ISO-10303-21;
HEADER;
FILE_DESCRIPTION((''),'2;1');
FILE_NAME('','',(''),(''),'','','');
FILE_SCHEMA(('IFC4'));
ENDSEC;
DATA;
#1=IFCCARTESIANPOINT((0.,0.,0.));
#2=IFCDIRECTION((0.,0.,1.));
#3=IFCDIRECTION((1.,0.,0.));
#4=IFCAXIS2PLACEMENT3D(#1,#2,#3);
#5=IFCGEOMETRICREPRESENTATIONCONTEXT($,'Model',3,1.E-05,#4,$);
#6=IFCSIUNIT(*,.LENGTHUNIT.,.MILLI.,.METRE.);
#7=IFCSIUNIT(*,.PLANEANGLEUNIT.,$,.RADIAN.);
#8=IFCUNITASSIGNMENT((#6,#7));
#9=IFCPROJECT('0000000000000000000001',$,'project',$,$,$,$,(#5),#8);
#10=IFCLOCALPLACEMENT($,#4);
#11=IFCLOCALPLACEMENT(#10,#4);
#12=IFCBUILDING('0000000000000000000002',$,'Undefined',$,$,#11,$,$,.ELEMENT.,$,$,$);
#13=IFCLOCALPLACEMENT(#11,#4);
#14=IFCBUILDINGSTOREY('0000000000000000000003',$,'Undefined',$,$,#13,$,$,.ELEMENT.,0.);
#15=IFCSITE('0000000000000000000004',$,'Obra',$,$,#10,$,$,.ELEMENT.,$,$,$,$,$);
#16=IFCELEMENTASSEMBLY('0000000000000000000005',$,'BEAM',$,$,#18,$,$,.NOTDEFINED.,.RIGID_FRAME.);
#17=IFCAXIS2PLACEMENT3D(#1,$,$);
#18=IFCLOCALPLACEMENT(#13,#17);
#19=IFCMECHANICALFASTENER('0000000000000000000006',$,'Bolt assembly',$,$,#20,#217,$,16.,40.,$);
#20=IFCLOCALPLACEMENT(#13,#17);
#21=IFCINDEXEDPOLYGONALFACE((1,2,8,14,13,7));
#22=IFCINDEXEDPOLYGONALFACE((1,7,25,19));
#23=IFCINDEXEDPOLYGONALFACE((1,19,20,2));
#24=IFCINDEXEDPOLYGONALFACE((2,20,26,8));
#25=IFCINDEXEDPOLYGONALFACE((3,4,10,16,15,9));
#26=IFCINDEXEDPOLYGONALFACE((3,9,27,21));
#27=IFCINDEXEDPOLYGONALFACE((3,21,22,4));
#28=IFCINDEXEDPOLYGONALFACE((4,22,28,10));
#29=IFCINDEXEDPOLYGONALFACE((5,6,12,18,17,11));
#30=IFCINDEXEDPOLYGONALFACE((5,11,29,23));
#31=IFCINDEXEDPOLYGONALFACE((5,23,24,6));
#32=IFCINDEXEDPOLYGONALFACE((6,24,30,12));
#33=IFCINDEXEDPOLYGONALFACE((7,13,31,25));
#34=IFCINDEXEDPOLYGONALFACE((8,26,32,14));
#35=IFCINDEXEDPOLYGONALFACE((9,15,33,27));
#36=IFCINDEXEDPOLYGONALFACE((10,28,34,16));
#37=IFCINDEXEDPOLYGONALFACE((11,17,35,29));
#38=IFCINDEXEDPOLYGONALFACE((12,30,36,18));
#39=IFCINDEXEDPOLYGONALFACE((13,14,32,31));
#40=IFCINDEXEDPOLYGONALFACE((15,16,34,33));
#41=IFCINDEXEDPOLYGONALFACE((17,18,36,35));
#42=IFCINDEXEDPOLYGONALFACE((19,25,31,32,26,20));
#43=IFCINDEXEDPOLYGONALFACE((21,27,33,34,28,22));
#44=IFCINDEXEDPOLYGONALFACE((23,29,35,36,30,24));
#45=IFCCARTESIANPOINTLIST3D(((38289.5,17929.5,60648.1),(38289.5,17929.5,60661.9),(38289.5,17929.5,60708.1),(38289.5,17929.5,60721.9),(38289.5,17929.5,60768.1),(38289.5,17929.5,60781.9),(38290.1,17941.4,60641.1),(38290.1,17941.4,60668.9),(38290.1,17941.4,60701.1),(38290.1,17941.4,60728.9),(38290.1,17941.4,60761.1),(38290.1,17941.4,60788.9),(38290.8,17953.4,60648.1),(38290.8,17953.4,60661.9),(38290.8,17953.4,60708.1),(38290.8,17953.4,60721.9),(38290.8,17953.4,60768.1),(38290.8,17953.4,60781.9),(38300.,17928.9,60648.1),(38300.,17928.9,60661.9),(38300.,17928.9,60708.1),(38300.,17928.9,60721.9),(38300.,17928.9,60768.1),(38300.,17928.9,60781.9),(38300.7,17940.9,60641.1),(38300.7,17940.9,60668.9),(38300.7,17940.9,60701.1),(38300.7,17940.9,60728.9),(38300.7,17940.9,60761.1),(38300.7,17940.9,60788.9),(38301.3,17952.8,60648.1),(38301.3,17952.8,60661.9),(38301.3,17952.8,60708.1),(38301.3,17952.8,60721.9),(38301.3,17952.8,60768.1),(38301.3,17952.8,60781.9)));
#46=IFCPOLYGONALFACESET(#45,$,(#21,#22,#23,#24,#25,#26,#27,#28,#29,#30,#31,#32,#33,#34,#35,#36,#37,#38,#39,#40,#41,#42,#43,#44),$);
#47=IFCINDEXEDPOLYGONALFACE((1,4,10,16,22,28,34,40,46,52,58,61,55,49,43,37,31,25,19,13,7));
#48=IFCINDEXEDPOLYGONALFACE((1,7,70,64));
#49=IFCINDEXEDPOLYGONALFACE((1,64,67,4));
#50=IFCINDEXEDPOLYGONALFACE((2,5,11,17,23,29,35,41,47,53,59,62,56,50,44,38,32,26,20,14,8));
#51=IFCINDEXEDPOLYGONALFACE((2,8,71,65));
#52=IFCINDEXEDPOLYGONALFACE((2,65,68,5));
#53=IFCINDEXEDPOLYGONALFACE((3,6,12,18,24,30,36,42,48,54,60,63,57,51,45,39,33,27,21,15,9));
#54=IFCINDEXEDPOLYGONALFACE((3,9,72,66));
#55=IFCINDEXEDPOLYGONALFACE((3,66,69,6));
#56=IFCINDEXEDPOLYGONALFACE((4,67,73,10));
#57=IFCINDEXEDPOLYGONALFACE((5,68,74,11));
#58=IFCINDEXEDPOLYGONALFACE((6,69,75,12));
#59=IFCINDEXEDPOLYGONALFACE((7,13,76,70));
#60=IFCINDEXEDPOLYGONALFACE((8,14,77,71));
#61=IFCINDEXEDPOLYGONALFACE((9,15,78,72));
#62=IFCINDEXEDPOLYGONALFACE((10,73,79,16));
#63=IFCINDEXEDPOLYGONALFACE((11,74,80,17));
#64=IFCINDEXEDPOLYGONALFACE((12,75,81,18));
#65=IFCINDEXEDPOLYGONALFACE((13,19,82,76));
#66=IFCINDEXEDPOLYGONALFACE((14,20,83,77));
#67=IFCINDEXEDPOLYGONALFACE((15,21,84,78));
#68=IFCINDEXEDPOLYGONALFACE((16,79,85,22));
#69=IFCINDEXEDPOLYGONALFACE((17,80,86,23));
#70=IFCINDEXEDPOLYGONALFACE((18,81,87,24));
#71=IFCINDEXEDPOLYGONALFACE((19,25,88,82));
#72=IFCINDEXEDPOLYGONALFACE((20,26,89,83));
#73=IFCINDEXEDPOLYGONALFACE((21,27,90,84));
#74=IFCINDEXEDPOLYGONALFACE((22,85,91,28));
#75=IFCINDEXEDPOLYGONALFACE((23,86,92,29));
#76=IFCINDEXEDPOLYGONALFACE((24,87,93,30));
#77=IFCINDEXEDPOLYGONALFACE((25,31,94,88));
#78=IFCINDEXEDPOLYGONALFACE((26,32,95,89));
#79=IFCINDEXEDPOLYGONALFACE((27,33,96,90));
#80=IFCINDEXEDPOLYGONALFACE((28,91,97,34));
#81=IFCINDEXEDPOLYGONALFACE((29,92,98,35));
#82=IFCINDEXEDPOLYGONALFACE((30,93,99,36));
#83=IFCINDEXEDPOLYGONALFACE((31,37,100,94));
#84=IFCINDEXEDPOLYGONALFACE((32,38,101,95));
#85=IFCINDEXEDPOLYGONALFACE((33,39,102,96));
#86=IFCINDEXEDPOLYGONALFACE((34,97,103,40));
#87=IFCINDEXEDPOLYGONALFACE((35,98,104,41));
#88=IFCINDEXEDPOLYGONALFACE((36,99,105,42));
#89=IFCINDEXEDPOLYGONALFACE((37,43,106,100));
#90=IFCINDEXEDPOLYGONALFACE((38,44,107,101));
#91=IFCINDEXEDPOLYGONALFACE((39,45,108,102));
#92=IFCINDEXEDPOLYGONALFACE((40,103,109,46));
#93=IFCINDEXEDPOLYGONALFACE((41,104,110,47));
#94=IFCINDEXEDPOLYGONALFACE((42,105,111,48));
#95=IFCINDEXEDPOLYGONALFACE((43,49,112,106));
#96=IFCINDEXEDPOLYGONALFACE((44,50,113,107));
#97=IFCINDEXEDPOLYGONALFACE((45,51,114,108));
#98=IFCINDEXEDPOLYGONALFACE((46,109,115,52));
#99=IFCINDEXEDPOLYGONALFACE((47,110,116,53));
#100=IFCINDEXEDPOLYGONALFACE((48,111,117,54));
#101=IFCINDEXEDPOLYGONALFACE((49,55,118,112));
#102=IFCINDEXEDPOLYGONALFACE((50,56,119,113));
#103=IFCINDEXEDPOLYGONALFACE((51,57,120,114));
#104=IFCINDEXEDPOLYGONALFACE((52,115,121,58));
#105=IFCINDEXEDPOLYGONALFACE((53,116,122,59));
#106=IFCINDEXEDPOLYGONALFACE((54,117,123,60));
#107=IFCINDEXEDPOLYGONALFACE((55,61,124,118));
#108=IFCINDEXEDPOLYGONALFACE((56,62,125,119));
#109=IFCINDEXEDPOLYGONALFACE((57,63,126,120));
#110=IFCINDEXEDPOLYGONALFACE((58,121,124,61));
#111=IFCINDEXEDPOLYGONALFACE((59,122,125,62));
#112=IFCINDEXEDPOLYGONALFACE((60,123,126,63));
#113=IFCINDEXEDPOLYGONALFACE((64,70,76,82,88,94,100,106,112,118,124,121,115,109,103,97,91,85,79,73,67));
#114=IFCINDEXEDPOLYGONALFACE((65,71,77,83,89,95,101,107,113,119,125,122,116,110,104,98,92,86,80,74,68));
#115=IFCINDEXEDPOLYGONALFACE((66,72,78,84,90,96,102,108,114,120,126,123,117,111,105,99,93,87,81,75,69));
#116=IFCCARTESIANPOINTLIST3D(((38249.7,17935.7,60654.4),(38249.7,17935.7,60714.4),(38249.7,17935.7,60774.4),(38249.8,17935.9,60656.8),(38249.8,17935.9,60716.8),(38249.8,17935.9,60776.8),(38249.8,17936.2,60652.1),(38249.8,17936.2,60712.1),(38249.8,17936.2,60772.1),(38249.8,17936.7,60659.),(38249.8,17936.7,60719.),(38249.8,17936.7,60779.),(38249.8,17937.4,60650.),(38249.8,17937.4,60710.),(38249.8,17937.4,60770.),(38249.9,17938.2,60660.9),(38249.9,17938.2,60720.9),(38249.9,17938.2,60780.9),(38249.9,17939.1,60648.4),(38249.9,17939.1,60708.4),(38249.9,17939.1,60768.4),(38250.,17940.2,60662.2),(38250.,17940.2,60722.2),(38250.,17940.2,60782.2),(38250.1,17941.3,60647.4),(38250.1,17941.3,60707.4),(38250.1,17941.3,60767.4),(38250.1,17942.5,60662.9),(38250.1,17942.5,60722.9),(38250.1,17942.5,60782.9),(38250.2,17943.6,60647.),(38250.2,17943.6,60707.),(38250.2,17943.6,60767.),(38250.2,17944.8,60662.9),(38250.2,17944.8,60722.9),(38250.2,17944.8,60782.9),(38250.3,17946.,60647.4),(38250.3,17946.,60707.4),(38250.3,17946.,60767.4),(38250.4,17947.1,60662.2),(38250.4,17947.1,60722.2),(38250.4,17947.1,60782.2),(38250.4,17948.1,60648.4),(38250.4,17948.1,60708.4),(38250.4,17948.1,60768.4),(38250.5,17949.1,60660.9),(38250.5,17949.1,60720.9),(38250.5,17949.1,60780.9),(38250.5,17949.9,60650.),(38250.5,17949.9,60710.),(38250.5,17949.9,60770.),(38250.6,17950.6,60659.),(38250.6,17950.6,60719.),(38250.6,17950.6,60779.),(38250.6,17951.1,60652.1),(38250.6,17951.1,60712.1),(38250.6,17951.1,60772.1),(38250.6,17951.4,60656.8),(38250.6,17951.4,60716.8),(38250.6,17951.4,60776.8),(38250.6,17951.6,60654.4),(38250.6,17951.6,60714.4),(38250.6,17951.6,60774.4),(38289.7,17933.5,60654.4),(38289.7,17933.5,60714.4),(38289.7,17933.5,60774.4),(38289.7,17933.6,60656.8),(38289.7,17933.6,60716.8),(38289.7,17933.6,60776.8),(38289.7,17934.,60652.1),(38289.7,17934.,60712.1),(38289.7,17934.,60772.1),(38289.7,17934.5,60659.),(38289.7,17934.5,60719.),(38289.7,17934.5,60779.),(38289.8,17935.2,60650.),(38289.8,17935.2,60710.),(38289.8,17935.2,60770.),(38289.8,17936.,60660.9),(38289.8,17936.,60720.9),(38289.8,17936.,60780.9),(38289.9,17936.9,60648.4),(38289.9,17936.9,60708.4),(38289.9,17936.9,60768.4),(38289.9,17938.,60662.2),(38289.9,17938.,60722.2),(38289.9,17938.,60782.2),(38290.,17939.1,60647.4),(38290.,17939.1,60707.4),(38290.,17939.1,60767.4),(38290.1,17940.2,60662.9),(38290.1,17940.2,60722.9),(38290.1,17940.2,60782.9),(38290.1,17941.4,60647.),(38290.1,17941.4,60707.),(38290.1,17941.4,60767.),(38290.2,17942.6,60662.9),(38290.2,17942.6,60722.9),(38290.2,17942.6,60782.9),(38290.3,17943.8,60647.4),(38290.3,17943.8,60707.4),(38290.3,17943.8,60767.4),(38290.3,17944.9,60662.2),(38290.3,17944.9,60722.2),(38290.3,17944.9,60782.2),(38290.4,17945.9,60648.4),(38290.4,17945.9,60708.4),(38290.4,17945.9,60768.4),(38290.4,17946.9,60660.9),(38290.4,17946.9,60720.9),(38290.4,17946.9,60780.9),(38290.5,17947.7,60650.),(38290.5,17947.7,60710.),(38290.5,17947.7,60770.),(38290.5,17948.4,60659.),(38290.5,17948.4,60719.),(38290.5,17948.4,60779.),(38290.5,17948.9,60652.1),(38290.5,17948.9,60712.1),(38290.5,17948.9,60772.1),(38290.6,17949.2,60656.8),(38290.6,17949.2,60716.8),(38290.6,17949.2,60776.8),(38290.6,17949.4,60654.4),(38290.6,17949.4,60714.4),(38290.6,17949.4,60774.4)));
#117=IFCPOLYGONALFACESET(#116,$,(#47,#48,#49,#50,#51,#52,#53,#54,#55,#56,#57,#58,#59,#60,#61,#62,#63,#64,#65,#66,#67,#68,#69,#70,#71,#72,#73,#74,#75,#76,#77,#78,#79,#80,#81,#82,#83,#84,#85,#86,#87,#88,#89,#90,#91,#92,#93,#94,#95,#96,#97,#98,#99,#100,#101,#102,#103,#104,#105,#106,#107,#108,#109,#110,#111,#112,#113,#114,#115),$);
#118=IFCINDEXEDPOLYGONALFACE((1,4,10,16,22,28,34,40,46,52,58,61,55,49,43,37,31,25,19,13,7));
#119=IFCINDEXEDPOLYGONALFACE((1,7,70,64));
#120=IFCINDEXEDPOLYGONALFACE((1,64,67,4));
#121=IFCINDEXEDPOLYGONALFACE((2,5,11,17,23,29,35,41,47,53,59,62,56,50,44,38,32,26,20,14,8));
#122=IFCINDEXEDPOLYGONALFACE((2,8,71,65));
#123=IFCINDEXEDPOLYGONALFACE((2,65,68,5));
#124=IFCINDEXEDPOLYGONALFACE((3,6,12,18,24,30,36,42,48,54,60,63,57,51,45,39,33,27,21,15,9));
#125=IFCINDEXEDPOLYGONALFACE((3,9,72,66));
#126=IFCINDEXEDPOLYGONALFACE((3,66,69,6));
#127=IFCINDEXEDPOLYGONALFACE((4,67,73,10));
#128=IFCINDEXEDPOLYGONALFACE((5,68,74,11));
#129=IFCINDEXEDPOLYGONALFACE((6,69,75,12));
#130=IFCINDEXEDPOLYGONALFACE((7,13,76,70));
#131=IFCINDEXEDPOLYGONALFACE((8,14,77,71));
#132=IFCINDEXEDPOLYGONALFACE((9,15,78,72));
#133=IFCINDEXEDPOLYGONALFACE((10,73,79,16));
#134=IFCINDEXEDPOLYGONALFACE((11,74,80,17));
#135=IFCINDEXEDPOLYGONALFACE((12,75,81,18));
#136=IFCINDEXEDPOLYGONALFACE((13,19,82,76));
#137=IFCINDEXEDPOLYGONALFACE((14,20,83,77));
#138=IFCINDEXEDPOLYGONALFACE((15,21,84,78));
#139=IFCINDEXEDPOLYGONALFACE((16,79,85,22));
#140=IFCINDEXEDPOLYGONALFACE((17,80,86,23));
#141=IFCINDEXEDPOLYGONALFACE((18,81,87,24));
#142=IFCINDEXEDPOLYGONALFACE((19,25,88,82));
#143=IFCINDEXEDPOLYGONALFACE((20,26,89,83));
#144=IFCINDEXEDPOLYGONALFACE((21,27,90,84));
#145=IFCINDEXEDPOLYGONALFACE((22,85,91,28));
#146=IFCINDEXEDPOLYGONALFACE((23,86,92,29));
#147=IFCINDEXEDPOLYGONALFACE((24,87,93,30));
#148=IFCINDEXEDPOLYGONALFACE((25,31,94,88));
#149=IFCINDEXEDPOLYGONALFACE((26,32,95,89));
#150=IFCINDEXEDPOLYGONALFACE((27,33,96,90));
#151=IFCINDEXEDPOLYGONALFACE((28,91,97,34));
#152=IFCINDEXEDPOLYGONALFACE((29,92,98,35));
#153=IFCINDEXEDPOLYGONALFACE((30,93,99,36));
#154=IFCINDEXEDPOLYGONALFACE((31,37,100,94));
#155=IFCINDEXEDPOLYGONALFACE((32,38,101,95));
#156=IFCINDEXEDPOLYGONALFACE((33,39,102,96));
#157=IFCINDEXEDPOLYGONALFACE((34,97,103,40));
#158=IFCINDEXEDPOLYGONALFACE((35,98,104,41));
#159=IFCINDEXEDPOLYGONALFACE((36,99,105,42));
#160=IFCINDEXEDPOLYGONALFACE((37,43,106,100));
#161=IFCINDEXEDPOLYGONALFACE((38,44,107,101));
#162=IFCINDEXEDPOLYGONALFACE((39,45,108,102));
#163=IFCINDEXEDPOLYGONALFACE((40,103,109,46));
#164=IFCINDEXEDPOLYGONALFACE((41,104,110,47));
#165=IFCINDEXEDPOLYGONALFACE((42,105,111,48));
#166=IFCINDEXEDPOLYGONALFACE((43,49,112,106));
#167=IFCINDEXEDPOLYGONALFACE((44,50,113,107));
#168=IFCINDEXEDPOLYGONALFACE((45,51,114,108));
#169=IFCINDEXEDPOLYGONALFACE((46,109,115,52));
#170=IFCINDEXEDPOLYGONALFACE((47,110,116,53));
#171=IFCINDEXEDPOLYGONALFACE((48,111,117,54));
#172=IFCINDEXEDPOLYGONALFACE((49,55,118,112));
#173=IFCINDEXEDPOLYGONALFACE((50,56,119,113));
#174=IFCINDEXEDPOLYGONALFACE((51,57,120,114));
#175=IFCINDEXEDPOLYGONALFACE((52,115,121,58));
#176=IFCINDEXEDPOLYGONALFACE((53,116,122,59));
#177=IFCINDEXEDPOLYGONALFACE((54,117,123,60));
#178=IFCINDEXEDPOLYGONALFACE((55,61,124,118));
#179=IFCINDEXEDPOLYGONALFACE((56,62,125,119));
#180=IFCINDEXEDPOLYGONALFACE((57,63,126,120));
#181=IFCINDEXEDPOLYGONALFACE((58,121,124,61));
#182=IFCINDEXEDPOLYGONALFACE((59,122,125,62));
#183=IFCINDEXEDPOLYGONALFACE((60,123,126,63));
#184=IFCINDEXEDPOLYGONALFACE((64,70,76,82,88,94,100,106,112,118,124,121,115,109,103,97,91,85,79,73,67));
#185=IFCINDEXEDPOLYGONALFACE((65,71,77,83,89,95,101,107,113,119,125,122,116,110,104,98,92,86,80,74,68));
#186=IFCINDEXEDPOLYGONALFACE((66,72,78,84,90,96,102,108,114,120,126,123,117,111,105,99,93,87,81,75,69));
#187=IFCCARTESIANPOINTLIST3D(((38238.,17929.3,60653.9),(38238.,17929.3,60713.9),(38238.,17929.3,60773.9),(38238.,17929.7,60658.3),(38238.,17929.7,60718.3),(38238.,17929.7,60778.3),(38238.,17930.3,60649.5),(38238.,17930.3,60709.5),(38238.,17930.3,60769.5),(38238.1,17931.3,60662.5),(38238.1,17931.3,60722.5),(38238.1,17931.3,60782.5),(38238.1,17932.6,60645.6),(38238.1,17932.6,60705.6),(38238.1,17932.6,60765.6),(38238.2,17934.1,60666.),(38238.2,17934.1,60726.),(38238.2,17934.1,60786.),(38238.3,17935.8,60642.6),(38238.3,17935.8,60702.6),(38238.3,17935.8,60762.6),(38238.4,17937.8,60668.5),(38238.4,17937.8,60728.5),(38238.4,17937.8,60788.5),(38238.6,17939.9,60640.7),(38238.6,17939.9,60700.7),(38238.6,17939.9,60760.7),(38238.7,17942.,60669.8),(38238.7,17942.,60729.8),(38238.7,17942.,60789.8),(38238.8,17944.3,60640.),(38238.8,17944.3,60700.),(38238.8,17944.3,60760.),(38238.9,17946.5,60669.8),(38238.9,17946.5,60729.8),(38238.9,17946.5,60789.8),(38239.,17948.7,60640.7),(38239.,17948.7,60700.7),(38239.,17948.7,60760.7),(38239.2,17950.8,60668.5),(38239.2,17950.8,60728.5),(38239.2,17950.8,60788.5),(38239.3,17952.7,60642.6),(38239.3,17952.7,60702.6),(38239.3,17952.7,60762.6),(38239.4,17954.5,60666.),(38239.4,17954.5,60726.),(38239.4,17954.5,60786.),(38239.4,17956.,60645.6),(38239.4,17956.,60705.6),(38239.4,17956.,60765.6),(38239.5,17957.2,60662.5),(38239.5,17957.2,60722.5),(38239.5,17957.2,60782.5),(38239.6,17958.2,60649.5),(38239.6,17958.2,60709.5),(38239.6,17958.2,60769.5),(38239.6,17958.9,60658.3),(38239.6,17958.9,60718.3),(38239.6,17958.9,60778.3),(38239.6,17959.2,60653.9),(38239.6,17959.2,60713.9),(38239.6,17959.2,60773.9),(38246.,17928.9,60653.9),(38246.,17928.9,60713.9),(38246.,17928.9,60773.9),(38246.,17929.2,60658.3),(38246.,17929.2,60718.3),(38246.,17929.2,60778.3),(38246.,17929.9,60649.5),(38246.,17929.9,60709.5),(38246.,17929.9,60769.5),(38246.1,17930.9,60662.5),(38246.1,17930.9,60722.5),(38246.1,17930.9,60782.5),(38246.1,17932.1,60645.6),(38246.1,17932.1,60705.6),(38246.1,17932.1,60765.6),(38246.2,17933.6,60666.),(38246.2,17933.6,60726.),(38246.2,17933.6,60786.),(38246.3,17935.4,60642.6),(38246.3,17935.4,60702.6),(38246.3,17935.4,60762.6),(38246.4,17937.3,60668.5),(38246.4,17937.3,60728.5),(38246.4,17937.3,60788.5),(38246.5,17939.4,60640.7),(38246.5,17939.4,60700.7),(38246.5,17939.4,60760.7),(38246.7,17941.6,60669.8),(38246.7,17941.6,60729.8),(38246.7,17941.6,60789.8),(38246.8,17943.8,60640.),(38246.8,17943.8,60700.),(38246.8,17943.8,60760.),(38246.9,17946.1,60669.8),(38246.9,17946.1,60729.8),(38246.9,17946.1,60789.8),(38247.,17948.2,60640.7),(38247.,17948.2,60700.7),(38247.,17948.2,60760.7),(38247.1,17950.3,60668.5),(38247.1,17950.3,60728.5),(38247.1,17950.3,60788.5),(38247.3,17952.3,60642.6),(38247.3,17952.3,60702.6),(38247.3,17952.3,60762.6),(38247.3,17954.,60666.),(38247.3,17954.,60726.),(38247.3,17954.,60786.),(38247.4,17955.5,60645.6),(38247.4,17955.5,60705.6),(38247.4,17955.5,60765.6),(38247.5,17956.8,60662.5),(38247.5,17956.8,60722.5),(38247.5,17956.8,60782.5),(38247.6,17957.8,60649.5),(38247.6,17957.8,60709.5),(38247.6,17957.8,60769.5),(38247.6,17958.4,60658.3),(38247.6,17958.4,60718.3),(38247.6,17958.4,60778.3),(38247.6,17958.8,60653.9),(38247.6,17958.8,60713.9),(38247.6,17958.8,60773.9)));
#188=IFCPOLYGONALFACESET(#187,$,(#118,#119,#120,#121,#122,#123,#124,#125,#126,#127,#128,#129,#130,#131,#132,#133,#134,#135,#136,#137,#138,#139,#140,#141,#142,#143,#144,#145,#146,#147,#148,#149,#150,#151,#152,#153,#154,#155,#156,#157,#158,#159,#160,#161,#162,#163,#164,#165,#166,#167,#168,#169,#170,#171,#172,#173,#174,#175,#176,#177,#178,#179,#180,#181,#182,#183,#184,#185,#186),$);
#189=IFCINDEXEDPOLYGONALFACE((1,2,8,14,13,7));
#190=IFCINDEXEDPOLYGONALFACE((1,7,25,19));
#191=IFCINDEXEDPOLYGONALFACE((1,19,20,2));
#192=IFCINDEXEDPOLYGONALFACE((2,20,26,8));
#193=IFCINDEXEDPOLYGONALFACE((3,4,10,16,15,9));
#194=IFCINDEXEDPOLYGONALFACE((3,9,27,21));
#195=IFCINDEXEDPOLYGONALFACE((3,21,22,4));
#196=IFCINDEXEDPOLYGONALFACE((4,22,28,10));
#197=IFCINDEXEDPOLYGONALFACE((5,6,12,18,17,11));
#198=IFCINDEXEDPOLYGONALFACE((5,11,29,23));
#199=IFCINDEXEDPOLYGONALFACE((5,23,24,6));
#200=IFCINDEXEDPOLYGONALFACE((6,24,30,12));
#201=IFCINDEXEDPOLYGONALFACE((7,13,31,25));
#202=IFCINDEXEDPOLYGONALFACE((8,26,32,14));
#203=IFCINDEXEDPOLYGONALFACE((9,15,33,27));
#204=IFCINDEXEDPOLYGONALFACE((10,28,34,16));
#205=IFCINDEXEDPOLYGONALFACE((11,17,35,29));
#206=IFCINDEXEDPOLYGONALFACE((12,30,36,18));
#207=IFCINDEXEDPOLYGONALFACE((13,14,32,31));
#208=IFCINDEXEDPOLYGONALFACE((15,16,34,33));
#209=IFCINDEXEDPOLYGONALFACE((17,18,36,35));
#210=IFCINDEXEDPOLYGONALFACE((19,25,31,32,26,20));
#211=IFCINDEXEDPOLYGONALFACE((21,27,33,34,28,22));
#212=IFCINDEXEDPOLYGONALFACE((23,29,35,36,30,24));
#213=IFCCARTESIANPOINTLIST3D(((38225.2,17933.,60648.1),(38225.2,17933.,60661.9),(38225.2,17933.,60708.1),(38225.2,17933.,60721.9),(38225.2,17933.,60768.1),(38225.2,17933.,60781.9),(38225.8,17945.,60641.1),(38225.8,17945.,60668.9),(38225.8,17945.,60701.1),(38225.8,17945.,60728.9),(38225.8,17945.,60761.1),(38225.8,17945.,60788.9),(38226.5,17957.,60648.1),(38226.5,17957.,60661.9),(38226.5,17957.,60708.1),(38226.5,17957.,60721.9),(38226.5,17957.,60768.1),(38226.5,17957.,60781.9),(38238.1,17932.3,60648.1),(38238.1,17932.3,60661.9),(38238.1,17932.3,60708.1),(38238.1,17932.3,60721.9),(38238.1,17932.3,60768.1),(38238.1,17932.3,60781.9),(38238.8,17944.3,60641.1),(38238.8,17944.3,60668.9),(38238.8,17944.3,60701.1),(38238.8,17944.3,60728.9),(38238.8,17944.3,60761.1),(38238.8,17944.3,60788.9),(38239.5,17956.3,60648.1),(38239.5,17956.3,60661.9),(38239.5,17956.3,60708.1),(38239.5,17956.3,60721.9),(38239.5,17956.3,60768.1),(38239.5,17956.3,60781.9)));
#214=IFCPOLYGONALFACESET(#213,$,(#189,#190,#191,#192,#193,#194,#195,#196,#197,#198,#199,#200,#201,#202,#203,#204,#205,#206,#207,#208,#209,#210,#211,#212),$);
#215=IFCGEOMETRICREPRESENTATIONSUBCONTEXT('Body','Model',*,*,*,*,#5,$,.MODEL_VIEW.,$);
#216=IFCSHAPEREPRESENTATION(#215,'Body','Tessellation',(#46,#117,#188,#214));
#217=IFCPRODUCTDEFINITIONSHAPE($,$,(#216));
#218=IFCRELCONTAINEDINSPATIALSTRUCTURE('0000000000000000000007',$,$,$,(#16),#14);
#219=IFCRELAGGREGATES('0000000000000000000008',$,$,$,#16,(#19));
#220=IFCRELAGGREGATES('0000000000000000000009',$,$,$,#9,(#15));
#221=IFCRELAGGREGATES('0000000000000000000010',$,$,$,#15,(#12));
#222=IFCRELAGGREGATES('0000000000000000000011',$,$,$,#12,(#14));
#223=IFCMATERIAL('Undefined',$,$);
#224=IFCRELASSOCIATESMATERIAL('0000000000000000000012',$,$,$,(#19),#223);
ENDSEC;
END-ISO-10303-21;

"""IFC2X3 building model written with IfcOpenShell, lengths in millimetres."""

from ifc_helpers import new_model, si_unit, frame, origin_with_axes, origin_2d_with_axis, place, context, subcontext, project, spatial, polyline, circle, outline, extrude, source, transform, mapped, material, element, aggregate, save


model = new_model("IFC2X3")

# Units and contexts
model_context = context("Model", 3, precision=1e-05, world=origin_with_axes())
body_context = subcontext(model_context, "Body", "Model", "MODEL_VIEW")
ifc_project = project(units=[si_unit("LENGTHUNIT", "METRE", prefix="MILLI"), si_unit("PLANEANGLEUNIT", "RADIAN")], contexts=[model_context])

# Site, building, storey
site_placement = place(None, origin_with_axes())
site = spatial("IfcSite", under=ifc_project, at=site_placement, Name="Obra", CompositionType="ELEMENT")
building_placement = place(site_placement, origin_with_axes())
building = spatial("IfcBuilding", under=site, at=building_placement, Name="Undefined", CompositionType="ELEMENT")
storey_placement = place(building_placement, origin_with_axes())
storey = spatial("IfcBuildingStorey", under=building, at=storey_placement, Name="Undefined", CompositionType="ELEMENT", Elevation=0.0)

# Element assembly, mechanical fastener
ifc_material_1 = material(Name="Undefined")
shared_shape_1 = source(origin_with_axes(), body_context, "Body", "SweptSolid", [
    extrude(outline(polyline([(13.9, 0.0), (6.9, 12.0), (-6.9, 12.0), (-13.9, 0.0), (-6.9, -12.0), (6.9, -12.0), (13.9, 0.0)])), frame((0.0, -19.7, 0.0), z_axis=(0.0, 1.0, 0.0), x_axis=(1.0, 0.0, 0.0)), (0.0, 0.0, 1.0), 10.6),
    extrude(circle(Radius=8.0, at=origin_2d_with_axis()), frame((0.0, -9.1, 0.0), z_axis=(0.0, 1.0, 0.0), x_axis=(1.0, 0.0, 0.0)), (0.0, 0.0, 1.0), 40.0),
    extrude(circle(Radius=15.0, at=origin_2d_with_axis()), frame((0.0, 34.3, 0.0), z_axis=(0.0, 1.0, 0.0), x_axis=(1.0, 0.0, 0.0)), (0.0, 0.0, 1.0), 8.0),
    extrude(outline(polyline([(13.9, 0.0), (6.9, 12.0), (-6.9, 12.0), (-13.9, 0.0), (-6.9, -12.0), (6.9, -12.0), (13.9, 0.0)])), frame((0.0, 42.3, 0.0), z_axis=(0.0, 1.0, 0.0), x_axis=(1.0, 0.0, 0.0)), (0.0, 0.0, 1.0), 13.0),
])
assembly_1_placement = place(storey_placement, origin_with_axes())
assembly_1 = element("IfcElementAssembly", 1, at=assembly_1_placement, inside=storey, Name="BEAM", AssemblyPlace="NOTDEFINED", PredefinedType="RIGID_FRAME")
mechanical_fastener_1_placement = place(assembly_1_placement, frame((38278.3, 17892.0, 60835.0), z_axis=(0.055268, 0.998472, 0.0), x_axis=(0.0, 0.0, -1.0)))
mechanical_fastener_1 = element("IfcMechanicalFastener", 2, at=mechanical_fastener_1_placement, material=ifc_material_1, Name="Bolt assembly", NominalDiameter=16.0, NominalLength=40.0, context=body_context, shape_type="MappedRepresentation", body=[
    mapped(shared_shape_1, transform((60.0, 0.0, 50.0))),
    mapped(shared_shape_1, transform((120.0, 0.0, 50.0))),
    mapped(shared_shape_1, transform((180.0, 0.0, 50.0))),
])

aggregate(assembly_1, [mechanical_fastener_1])

save(model, "model.ifc")
